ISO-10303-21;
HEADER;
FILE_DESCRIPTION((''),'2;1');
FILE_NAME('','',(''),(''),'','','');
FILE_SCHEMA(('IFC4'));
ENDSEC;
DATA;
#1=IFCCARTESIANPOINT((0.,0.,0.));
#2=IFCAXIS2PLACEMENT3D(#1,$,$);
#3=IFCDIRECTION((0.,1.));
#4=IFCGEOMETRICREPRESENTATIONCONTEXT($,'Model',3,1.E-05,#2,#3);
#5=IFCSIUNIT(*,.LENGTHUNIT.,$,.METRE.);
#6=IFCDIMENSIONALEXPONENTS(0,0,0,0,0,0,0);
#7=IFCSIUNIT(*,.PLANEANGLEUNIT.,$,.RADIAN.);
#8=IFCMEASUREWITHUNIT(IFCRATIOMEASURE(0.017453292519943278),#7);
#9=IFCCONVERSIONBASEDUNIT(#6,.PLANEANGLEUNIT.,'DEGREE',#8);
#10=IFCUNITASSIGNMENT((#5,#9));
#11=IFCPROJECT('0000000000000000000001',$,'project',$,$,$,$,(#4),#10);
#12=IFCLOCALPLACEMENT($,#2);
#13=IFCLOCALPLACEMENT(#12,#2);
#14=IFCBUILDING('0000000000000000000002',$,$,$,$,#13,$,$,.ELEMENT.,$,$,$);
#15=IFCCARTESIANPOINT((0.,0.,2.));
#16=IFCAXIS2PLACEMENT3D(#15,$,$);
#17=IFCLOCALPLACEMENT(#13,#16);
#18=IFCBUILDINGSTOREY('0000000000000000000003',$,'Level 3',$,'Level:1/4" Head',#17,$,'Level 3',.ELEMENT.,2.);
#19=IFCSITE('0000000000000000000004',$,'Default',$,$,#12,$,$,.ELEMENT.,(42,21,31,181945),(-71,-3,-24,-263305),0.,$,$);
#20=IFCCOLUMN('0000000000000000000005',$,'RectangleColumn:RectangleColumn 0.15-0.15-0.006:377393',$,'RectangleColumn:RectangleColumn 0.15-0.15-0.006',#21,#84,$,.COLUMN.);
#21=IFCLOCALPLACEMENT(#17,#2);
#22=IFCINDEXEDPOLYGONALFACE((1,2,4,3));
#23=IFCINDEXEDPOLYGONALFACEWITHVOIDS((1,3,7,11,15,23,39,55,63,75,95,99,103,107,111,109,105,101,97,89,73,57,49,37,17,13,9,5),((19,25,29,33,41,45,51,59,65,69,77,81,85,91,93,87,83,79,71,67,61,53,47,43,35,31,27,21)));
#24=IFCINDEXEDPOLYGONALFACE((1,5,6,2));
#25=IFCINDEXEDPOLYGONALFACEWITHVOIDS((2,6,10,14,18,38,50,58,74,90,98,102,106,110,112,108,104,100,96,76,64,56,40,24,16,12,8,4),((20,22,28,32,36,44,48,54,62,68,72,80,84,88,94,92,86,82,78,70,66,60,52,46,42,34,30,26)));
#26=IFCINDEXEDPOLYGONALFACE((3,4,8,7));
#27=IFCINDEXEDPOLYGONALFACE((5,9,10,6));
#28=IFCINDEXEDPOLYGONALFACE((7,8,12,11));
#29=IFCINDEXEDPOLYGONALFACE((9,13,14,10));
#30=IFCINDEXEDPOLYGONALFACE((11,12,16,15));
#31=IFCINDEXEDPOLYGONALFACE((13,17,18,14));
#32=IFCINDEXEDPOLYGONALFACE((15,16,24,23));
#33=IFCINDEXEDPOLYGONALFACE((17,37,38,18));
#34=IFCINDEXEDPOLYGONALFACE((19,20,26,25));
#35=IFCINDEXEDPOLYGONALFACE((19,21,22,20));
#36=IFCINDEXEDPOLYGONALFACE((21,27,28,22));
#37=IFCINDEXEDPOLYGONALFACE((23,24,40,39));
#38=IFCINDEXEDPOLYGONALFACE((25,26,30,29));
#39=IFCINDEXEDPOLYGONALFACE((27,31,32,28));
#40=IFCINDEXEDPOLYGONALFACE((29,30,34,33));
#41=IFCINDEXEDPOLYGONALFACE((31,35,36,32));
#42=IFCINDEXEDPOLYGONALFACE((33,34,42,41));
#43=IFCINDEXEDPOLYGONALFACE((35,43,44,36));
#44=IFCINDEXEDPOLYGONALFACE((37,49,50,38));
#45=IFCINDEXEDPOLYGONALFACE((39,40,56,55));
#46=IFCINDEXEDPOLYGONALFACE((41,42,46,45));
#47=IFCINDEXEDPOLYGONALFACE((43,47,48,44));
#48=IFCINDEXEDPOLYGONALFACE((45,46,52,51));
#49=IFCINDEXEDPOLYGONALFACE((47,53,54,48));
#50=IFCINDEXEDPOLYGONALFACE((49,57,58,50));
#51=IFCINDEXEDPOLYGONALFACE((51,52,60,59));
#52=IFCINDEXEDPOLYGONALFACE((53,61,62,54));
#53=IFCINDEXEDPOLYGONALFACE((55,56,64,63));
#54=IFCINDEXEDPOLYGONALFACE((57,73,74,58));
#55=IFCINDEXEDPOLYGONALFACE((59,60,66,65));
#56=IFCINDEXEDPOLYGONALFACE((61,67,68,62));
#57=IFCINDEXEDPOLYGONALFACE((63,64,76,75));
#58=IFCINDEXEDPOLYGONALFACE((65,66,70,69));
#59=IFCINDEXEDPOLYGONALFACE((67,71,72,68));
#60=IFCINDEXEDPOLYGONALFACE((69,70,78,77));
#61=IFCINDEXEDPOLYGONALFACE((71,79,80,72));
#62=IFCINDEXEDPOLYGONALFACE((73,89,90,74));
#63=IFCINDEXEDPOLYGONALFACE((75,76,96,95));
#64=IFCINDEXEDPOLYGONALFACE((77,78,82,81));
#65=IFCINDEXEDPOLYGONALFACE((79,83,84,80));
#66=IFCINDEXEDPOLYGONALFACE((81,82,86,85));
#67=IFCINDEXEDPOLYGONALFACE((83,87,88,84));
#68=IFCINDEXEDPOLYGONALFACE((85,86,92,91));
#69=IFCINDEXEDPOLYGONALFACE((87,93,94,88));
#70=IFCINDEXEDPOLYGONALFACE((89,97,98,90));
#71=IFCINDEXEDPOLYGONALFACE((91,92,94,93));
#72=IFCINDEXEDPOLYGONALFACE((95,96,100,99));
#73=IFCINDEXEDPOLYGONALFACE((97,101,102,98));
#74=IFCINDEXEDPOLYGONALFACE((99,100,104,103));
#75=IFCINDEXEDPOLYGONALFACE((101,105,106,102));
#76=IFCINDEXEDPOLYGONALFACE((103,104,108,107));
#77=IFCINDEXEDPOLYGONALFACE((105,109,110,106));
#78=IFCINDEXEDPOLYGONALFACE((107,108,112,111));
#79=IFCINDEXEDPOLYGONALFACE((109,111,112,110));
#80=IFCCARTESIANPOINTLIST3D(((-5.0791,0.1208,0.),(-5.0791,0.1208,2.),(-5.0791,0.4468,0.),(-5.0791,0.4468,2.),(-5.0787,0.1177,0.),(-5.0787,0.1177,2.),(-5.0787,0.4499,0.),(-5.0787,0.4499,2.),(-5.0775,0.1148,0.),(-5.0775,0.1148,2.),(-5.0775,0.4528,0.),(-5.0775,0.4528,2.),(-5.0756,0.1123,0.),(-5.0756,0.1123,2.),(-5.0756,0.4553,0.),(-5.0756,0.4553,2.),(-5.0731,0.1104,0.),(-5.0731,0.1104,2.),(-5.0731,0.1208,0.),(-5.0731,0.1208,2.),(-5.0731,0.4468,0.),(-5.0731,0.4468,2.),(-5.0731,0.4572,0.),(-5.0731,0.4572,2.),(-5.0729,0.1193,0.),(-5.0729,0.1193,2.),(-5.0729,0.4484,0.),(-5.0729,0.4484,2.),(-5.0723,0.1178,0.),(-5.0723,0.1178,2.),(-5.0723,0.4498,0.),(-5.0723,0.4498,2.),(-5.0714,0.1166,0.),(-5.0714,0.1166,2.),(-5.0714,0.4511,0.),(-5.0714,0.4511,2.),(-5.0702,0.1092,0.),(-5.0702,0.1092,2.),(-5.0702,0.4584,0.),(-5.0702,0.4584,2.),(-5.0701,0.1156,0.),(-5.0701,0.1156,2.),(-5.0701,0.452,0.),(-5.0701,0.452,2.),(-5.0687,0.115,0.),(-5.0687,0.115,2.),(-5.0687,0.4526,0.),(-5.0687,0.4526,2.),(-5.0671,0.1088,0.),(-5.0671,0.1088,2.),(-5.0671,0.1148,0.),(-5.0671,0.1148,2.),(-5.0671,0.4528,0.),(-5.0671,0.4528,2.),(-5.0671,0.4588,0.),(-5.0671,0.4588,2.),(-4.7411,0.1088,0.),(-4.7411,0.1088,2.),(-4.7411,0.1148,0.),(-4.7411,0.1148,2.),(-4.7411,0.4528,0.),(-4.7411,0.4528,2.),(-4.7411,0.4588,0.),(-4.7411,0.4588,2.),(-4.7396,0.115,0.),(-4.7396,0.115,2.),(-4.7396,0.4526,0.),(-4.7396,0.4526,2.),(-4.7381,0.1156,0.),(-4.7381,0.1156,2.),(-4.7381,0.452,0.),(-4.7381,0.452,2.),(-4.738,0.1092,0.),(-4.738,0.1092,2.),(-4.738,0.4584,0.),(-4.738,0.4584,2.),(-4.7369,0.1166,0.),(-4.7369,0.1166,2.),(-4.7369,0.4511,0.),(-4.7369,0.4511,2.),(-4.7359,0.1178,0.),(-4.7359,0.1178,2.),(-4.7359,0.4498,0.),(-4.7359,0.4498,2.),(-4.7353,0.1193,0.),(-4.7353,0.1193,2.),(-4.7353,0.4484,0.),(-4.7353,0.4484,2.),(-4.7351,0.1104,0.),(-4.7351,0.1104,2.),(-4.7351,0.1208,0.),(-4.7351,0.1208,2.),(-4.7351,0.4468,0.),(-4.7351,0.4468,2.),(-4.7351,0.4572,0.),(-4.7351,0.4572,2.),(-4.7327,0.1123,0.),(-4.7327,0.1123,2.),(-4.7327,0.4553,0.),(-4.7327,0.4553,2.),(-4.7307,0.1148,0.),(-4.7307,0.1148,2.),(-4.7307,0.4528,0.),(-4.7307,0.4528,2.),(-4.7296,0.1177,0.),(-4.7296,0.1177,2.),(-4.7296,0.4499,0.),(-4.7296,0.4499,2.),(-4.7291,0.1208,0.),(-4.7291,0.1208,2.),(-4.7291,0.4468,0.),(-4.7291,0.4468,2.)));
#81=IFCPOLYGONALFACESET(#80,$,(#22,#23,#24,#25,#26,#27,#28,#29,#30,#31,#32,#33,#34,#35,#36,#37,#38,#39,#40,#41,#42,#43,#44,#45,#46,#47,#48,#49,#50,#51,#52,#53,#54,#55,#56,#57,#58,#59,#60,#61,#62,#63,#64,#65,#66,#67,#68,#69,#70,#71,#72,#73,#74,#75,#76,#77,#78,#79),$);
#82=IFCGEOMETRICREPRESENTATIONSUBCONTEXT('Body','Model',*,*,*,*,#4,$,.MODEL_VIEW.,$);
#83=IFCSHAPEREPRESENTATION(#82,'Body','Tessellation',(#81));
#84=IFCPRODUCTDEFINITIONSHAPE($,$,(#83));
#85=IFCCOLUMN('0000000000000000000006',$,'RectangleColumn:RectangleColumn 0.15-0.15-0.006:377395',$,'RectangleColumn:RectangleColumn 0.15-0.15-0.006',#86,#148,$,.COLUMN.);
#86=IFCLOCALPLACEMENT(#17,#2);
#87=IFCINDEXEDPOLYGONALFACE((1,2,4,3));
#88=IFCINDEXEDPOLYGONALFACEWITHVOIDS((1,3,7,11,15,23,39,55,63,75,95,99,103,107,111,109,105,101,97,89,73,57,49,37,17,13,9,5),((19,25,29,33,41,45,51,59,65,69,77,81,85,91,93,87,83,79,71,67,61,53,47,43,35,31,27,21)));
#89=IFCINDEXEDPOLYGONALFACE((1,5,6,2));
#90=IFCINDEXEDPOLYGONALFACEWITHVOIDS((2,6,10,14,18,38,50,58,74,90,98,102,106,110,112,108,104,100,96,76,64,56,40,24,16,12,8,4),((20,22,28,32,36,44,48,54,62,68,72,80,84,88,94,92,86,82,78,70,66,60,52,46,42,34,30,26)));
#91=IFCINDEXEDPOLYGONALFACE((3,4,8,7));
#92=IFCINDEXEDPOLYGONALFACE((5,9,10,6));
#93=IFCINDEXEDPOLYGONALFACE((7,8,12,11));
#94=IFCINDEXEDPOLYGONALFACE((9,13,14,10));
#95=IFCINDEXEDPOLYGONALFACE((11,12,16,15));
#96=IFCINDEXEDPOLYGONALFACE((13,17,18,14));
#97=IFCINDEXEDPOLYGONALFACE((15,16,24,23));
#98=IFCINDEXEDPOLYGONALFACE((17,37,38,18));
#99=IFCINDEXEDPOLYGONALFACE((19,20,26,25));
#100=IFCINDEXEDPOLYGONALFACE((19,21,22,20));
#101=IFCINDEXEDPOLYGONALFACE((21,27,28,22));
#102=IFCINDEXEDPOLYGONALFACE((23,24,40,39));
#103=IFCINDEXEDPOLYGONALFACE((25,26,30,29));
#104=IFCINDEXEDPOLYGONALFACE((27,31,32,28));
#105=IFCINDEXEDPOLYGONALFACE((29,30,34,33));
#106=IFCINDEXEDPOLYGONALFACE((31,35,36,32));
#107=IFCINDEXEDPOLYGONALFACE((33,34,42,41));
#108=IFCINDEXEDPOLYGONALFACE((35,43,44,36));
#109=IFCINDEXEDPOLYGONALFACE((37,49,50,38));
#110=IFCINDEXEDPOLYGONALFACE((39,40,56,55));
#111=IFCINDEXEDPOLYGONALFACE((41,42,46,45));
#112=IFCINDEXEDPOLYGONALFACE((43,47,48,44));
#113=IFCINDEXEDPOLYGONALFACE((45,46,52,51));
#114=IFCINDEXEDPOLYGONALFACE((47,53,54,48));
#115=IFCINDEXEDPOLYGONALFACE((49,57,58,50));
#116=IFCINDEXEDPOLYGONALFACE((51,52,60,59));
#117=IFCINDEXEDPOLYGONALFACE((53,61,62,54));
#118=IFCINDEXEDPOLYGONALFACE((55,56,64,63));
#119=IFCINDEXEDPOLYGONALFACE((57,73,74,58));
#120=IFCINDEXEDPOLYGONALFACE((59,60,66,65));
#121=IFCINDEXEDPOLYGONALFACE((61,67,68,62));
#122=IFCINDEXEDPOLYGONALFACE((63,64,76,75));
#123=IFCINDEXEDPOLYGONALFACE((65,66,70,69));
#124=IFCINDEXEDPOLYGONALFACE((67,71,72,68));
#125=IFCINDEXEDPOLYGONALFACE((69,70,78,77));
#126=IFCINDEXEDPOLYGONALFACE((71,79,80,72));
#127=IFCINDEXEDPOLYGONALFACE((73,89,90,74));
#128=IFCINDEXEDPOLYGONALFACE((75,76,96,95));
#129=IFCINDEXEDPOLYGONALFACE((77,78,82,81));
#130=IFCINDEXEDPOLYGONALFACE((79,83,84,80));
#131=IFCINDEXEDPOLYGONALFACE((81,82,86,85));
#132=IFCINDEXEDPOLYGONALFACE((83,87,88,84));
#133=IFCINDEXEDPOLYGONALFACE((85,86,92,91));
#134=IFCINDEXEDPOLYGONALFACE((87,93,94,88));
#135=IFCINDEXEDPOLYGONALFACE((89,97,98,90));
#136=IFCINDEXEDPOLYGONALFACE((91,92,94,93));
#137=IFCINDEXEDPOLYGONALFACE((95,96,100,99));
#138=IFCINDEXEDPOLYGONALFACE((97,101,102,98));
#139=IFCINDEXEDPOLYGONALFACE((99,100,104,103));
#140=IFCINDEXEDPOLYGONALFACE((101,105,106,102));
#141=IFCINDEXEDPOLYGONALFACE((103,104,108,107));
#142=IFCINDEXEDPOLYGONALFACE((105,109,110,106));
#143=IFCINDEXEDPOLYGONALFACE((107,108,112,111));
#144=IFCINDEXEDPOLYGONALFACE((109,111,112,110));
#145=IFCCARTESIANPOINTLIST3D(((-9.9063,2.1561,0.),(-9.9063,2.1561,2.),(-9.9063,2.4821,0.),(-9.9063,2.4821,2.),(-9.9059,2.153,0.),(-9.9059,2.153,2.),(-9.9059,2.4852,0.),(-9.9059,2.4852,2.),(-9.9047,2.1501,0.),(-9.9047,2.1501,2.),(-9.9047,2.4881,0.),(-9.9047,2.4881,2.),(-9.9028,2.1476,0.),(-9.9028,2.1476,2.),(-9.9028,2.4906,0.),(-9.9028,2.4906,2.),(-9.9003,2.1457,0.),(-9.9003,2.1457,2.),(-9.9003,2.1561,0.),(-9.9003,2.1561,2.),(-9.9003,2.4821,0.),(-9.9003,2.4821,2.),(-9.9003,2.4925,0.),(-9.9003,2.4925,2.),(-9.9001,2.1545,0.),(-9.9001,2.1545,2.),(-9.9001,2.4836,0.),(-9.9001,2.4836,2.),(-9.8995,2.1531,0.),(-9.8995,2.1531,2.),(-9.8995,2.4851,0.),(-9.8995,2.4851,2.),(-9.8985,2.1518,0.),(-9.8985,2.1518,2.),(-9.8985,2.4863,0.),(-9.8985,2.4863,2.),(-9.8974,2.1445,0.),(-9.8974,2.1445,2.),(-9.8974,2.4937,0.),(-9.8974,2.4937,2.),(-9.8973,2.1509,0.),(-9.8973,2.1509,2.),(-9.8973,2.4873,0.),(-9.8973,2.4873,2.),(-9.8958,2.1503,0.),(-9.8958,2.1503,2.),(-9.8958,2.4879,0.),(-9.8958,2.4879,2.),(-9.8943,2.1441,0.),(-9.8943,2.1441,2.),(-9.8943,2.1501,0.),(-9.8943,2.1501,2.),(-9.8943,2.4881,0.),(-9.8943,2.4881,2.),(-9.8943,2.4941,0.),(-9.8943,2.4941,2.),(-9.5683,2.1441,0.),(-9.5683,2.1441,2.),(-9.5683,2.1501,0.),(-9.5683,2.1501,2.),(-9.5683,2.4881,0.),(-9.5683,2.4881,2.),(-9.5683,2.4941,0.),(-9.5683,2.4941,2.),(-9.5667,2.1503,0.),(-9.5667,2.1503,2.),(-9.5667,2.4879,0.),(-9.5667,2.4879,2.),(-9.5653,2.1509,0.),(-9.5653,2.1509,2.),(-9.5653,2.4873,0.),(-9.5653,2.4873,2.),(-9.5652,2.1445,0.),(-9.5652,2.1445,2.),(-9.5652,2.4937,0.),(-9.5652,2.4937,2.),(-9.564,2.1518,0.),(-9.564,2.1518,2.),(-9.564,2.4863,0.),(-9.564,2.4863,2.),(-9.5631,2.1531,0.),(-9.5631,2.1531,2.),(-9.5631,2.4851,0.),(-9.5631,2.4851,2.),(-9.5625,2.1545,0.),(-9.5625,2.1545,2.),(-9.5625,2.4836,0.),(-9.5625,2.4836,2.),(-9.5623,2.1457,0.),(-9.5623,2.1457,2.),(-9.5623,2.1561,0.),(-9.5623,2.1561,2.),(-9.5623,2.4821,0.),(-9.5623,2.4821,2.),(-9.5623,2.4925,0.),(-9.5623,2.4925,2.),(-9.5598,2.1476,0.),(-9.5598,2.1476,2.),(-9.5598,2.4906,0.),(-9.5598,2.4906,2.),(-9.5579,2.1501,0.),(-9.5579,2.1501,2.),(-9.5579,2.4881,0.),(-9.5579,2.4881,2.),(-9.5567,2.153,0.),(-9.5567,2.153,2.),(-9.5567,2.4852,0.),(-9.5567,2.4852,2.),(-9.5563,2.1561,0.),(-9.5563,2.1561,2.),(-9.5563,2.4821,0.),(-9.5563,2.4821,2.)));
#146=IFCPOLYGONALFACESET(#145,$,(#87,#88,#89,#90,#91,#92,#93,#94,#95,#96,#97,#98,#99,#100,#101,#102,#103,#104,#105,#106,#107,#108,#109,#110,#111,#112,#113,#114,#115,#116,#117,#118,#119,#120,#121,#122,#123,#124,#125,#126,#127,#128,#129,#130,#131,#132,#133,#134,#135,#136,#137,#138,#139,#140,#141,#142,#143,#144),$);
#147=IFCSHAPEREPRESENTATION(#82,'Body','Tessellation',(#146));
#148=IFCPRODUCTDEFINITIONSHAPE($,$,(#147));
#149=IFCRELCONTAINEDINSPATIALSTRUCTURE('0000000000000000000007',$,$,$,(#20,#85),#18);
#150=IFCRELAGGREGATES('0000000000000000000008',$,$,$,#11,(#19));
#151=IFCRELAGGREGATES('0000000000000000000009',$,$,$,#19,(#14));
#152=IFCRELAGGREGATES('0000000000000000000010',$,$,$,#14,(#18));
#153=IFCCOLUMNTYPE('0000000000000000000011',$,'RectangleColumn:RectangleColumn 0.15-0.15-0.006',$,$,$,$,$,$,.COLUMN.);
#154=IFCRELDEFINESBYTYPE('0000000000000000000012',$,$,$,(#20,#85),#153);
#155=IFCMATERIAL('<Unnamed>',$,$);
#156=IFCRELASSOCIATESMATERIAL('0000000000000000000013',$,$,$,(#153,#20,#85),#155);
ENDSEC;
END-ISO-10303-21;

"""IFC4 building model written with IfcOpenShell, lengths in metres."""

from ifc_helpers import new_model, entity, si_unit, converted_unit, direction, frame, origin, place, context, subcontext, project, spatial, line, arc, indexed_curve, outline, extrude, source, transform, mapped, material, type_object, type_shapes, element, save


model = new_model("IFC4")

# Units and contexts
model_context = context("Model", 3, precision=1e-05, world=origin(), true_north=direction((0.0, 1.0)))
body_context = subcontext(model_context, "Body", "Model", "MODEL_VIEW")
ifc_project = project(units=[si_unit("LENGTHUNIT", "METRE"), converted_unit("PLANEANGLEUNIT", "DEGREE", entity("IfcRatioMeasure", 0.017453292519943278), si_unit("PLANEANGLEUNIT", "RADIAN"), dimensions=[0, 0, 0, 0, 0, 0, 0])], contexts=[model_context])

# Site, building, storey
site_placement = place(None, origin())
site = spatial("IfcSite", under=ifc_project, at=site_placement, Name="Default", CompositionType="ELEMENT", RefLatitude=(42, 21, 31, 181945), RefLongitude=(-71, -3, -24, -263305), RefElevation=0.0)
building_placement = place(site_placement, origin())
building = spatial("IfcBuilding", under=site, at=building_placement, CompositionType="ELEMENT")
storey_placement = place(building_placement, frame((0.0, 0.0, 2.0)))
storey = spatial("IfcBuildingStorey", under=building, at=storey_placement, Name="Level 3", ObjectType="Level:1/4\" Head", LongName="Level 3", CompositionType="ELEMENT", Elevation=2.0)

# Columns
ifc_material_1 = material(Name="<Unnamed>")
column_type = type_object("IfcColumnType", Name="RectangleColumn:RectangleColumn 0.15-0.15-0.006", PredefinedType="COLUMN", material=ifc_material_1)
shared_shape = source(origin(), body_context, "Body", "SweptSolid", [
    extrude(outline(indexed_curve([(-0.163, -0.175), (0.163, -0.175), (0.1715, -0.1715), (0.175, -0.163), (0.175, 0.163), (0.1715, 0.1715), (0.163, 0.175), (-0.163, 0.175), (-0.1715, 0.1715), (-0.175, 0.163), (-0.175, -0.163), (-0.1715, -0.1715)], segments=[line(1, 2), arc(2, 3, 4), line(4, 5), arc(5, 6, 7), line(7, 8), arc(8, 9, 10), line(10, 11), arc(11, 12, 1)], self_intersect=False), holes=[indexed_curve([(-0.163, -0.169), (-0.1672, -0.1672), (-0.169, -0.163), (-0.169, 0.163), (-0.1672, 0.1672), (-0.163, 0.169), (0.163, 0.169), (0.1672, 0.1672), (0.169, 0.163), (0.169, -0.163), (0.1672, -0.1672), (0.163, -0.169)], segments=[arc(1, 2, 3), line(3, 4), arc(4, 5, 6), line(6, 7), arc(7, 8, 9), line(9, 10), arc(10, 11, 12), line(12, 1)], self_intersect=False)]), frame((0.0, 0.0, 2.0), z_axis=(0.0, 0.0, 1.0), x_axis=(-1.0, 0.0, 0.0)), (0.0, 0.0, 1.0), 2.0),
])
type_shapes(column_type, [shared_shape])
for number, where, name in (
    (1, (-4.9041, 0.2838, -2.0), "RectangleColumn:RectangleColumn 0.15-0.15-0.006:377393"),
    (2, (-9.7313, 2.3191, -2.0), "RectangleColumn:RectangleColumn 0.15-0.15-0.006:377395"),
):
    element("IfcColumn", number, at=place(storey_placement, frame(where)), inside=storey, type_object=column_type, material=ifc_material_1, Name=name, ObjectType="RectangleColumn:RectangleColumn 0.15-0.15-0.006", PredefinedType="COLUMN", context=body_context, shape_type="MappedRepresentation", body=[
        mapped(shared_shape, transform((0.0, 0.0, 0.0), scale=1.0)),
    ])

save(model, "model.ifc")
